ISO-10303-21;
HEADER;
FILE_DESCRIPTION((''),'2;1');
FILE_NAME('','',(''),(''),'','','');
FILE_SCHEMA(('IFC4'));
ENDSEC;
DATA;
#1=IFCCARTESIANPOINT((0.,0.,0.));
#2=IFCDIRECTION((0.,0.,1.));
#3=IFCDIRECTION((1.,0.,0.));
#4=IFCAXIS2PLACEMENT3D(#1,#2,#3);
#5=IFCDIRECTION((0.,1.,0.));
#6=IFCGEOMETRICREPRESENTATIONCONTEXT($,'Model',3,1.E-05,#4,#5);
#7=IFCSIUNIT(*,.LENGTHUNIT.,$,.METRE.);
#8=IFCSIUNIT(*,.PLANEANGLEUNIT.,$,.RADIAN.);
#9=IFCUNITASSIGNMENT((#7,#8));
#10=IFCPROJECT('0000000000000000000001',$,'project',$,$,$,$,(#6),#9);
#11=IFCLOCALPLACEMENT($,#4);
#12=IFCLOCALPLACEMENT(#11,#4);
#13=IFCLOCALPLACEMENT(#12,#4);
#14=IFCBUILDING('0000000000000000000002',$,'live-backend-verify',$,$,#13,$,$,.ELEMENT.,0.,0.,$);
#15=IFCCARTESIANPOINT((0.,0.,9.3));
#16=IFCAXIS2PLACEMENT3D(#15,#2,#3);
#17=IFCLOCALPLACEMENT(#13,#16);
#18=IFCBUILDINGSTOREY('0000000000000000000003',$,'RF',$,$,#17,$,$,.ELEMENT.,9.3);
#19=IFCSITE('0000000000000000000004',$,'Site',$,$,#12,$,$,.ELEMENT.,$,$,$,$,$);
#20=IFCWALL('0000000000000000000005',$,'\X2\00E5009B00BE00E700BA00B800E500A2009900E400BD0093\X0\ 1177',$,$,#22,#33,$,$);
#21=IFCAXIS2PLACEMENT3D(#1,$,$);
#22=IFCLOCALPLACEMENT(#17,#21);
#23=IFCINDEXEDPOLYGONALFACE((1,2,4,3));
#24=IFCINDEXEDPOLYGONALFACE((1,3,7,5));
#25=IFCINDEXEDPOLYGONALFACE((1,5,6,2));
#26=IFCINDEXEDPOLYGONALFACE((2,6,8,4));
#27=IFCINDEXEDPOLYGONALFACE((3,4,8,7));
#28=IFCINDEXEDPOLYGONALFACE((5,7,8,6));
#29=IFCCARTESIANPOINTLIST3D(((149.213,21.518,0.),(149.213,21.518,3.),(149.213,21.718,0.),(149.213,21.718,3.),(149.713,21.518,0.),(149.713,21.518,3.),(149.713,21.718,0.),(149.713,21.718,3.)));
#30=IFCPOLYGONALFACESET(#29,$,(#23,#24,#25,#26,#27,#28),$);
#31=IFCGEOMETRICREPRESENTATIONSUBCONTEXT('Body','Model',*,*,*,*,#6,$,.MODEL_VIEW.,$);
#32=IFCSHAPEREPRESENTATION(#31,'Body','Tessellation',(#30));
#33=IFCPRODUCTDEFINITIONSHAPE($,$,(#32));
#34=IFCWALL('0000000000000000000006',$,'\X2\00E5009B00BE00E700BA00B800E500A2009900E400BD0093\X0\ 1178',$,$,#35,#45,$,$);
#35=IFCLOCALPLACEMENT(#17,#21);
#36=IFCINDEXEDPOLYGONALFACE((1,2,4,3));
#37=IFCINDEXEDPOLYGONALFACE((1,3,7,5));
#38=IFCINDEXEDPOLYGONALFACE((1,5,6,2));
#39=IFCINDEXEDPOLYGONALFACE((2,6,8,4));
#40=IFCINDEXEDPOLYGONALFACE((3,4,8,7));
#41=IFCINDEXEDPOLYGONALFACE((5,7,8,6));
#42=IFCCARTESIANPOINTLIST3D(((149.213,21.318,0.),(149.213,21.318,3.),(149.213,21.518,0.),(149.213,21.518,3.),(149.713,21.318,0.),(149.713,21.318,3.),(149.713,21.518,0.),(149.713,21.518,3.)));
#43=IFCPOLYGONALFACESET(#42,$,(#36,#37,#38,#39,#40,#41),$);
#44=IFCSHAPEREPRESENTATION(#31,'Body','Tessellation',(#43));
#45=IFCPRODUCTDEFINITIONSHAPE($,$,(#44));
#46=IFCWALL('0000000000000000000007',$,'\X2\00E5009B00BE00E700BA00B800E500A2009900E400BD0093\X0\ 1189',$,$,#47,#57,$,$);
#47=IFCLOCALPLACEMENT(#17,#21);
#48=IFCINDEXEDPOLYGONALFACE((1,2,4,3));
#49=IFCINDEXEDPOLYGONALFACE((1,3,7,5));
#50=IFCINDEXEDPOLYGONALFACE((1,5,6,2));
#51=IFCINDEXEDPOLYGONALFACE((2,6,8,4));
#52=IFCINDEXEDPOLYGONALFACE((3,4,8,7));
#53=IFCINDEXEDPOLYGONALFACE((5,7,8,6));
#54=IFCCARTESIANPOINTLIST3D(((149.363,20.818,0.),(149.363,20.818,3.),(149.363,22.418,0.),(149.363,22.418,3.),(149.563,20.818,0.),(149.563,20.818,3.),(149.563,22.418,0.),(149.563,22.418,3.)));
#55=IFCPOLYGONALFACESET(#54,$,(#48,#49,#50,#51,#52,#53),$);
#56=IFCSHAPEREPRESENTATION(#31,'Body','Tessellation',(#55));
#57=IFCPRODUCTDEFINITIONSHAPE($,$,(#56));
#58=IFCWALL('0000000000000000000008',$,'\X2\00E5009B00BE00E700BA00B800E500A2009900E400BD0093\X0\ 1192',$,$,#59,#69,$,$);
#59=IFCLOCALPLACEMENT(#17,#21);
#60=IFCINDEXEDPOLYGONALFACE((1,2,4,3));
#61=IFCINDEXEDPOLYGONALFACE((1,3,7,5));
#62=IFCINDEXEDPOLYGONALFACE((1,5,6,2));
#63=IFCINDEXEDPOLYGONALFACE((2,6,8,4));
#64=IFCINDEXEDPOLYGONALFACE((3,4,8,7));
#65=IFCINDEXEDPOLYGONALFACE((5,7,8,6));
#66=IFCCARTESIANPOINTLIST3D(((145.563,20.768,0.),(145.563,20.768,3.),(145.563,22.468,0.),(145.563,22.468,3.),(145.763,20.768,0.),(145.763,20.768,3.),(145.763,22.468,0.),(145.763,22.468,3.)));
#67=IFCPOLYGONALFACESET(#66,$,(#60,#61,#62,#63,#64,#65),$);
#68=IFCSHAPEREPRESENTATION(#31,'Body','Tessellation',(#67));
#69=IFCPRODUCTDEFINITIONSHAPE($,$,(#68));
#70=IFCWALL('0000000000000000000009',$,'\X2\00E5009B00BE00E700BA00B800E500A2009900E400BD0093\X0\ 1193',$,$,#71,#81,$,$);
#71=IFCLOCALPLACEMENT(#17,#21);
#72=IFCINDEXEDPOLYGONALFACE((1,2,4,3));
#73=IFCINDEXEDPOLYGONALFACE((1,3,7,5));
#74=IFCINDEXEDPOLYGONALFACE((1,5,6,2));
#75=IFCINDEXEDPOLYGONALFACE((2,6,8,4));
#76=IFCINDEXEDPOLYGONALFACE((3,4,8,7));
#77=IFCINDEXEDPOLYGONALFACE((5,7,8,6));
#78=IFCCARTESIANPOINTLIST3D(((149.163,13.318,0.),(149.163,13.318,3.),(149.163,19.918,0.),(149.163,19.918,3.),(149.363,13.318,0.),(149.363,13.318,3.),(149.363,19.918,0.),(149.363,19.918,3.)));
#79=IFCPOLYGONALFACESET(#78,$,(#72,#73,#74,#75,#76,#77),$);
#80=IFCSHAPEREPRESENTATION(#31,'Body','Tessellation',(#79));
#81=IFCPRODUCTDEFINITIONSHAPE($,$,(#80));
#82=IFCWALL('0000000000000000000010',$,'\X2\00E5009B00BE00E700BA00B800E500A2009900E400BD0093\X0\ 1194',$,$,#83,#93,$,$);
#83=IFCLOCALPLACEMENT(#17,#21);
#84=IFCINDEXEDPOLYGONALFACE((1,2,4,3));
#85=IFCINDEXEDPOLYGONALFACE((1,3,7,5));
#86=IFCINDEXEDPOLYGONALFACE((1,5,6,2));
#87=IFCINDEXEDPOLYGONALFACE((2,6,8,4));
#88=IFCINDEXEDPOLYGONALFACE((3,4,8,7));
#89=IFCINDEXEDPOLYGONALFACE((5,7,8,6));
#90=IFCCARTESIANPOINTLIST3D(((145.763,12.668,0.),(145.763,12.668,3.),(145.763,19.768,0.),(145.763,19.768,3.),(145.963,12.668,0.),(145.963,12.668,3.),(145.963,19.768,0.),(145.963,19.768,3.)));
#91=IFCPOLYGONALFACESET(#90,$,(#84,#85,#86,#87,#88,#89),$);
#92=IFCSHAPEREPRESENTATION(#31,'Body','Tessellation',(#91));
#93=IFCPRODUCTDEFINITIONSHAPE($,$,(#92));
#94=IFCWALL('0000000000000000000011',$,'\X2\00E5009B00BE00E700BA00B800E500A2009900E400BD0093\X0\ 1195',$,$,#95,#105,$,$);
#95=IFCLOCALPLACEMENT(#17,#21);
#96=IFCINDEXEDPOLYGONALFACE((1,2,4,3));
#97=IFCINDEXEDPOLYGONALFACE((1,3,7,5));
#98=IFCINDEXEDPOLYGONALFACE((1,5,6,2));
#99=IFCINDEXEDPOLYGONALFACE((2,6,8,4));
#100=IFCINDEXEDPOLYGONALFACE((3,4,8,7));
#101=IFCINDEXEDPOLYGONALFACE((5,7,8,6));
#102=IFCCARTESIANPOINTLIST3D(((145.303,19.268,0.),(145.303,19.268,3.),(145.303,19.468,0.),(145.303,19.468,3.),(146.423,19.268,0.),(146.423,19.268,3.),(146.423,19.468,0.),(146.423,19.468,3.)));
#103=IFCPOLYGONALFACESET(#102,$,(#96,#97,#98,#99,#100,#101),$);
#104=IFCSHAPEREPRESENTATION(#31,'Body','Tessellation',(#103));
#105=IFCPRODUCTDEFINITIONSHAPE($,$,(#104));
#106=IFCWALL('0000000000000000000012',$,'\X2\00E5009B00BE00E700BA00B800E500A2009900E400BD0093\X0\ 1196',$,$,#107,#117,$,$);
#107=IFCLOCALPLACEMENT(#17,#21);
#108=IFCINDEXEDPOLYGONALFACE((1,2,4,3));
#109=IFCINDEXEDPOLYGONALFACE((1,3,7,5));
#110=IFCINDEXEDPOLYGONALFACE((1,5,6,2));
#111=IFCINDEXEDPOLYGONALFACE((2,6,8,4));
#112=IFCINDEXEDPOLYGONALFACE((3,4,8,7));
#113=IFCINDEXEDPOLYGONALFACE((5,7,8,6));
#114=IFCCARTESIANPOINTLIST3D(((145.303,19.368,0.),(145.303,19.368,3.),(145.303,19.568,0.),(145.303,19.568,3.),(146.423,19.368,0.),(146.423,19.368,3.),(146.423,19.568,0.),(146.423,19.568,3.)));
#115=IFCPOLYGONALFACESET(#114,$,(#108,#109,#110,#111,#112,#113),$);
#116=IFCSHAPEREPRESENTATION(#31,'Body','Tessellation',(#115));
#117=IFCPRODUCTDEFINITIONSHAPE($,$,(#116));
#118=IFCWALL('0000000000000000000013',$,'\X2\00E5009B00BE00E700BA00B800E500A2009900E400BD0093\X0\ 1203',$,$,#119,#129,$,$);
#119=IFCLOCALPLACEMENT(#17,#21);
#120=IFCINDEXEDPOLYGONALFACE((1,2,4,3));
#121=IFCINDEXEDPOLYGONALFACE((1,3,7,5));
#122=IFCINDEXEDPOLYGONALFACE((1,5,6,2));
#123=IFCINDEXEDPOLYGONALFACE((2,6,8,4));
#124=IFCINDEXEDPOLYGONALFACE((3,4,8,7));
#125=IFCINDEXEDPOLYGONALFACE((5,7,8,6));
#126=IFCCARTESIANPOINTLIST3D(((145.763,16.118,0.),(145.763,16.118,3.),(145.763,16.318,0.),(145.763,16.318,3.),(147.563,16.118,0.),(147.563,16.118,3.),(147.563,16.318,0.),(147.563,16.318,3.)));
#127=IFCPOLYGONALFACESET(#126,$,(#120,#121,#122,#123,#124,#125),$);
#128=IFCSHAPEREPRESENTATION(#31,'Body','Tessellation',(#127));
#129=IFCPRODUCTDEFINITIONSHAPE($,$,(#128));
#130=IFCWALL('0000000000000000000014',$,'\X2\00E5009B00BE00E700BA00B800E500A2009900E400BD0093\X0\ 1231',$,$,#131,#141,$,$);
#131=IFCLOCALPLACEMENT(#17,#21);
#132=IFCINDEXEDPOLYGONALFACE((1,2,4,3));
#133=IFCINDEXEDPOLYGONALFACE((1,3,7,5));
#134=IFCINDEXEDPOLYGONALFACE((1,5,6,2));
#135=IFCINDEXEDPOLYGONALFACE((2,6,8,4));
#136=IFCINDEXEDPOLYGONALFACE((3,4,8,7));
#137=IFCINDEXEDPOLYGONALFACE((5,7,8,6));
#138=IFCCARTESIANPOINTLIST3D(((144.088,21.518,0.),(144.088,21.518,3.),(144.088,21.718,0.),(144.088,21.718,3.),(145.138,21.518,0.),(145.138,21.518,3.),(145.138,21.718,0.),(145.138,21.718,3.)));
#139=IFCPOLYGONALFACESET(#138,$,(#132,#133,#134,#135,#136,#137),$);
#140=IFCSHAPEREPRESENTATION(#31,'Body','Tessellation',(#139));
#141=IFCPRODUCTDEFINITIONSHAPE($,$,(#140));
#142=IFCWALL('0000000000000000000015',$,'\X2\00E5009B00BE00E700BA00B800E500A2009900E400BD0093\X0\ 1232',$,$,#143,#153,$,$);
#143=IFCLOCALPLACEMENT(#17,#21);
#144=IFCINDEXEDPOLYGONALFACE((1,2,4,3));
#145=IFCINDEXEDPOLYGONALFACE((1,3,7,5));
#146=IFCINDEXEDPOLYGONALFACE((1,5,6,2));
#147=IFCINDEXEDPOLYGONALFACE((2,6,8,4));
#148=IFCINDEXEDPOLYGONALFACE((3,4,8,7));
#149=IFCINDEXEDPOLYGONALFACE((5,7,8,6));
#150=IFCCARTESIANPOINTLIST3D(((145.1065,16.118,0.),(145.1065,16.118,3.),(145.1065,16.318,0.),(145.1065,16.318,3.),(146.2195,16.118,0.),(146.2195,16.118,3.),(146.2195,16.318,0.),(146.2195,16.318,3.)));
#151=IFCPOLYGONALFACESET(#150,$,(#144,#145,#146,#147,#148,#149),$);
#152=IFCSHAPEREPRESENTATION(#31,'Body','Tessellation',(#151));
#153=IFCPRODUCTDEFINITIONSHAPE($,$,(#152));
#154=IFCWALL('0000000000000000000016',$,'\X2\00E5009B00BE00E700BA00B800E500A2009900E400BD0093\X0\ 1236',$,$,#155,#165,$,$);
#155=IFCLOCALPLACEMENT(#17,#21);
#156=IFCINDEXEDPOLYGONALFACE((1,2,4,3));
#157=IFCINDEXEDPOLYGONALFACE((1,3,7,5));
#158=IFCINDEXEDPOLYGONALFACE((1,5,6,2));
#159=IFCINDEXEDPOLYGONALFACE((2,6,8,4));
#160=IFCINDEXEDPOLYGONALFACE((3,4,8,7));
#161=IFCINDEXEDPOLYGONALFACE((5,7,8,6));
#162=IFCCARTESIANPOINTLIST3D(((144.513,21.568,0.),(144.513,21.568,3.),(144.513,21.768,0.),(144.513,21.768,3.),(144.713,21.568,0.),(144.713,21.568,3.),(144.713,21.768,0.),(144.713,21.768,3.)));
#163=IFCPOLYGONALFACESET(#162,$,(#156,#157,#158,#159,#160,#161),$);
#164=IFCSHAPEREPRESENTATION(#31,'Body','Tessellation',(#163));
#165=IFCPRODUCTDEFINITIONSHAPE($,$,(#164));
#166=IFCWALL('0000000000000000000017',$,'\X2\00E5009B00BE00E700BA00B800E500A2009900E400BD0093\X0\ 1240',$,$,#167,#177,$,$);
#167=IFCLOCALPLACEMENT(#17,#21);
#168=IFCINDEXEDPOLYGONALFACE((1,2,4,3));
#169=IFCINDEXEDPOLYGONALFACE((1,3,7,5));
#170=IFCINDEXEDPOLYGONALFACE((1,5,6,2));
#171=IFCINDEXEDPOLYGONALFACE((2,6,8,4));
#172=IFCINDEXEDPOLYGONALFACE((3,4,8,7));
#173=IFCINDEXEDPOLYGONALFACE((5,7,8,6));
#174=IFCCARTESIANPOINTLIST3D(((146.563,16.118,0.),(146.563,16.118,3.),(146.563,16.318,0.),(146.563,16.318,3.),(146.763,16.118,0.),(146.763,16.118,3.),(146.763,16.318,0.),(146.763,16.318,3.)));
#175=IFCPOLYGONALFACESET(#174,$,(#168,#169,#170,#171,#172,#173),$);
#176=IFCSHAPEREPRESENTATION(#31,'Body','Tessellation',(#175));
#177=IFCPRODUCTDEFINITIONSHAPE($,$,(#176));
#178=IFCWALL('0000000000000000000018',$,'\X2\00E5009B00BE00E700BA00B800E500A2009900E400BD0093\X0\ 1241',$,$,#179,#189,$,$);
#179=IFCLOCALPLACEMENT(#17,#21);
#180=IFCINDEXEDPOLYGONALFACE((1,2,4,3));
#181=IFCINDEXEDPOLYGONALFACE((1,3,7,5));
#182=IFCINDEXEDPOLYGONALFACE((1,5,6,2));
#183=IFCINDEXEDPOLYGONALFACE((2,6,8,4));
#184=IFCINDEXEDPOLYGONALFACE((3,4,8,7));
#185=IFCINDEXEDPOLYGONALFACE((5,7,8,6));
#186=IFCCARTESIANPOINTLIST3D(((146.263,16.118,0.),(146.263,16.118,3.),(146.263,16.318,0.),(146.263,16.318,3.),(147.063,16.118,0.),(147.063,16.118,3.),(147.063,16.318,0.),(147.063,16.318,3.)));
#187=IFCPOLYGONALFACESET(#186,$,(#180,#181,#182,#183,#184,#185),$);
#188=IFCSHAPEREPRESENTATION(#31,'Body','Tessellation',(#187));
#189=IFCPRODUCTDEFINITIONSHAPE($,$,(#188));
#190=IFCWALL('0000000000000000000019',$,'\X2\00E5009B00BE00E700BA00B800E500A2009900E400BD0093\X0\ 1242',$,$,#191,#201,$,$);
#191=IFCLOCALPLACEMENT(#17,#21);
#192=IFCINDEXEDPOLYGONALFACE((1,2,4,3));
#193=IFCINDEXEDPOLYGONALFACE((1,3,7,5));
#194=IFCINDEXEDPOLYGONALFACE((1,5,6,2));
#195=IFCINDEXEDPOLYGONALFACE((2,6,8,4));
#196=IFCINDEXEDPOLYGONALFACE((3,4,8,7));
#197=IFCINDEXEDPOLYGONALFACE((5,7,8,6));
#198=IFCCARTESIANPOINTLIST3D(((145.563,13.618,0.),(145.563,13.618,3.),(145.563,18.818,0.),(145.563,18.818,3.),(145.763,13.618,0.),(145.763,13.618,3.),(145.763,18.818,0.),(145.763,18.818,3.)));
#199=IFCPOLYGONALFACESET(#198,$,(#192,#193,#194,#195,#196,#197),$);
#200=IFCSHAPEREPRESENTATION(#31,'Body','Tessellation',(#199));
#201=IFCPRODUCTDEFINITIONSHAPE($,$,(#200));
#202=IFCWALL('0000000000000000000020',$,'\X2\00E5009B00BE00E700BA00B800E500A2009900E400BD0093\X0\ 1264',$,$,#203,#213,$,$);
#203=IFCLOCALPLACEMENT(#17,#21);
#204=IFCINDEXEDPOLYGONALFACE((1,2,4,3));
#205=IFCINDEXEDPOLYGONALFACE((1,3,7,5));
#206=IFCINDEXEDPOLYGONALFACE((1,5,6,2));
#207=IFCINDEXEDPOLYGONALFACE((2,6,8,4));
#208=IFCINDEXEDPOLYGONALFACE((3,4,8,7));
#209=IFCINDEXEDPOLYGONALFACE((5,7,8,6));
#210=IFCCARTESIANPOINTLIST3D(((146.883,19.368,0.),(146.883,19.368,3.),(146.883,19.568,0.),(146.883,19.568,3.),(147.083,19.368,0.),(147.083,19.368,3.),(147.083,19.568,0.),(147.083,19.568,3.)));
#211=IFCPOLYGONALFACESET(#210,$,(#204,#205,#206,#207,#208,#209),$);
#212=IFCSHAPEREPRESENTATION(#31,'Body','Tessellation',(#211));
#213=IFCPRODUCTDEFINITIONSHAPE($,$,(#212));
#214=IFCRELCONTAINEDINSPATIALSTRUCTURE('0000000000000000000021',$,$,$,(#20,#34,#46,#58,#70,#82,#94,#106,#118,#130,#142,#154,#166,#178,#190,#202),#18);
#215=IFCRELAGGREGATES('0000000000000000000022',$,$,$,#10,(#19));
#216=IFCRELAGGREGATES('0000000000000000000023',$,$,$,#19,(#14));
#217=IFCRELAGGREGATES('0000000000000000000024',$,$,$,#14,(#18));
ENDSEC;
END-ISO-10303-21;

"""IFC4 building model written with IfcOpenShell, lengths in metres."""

from ifc_helpers import new_model, si_unit, direction, frame, frame_2d, origin_with_axes, place, context, subcontext, project, spatial, rectangle, extrude, element, save


model = new_model("IFC4")

# Units and contexts
model_context = context("Model", 3, precision=1e-05, world=origin_with_axes(), true_north=direction((0.0, 1.0, 0.0)))
body_context = subcontext(model_context, "Body", "Model", "MODEL_VIEW")
ifc_project = project(units=[si_unit("LENGTHUNIT", "METRE"), si_unit("PLANEANGLEUNIT", "RADIAN")], contexts=[model_context])

# Site, building, storey
placement = place(None, origin_with_axes())
site_placement = place(placement, origin_with_axes())
site = spatial("IfcSite", under=ifc_project, at=site_placement, Name="Site", CompositionType="ELEMENT")
building_placement = place(site_placement, origin_with_axes())
building = spatial("IfcBuilding", under=site, at=building_placement, Name="live-backend-verify", CompositionType="ELEMENT", ElevationOfRefHeight=0.0, ElevationOfTerrain=0.0)
storey_placement = place(building_placement, frame((0.0, 0.0, 9.3), z_axis=(0.0, 0.0, 1.0), x_axis=(1.0, 0.0, 0.0)))
storey = spatial("IfcBuildingStorey", under=building, at=storey_placement, Name="RF", CompositionType="ELEMENT", Elevation=9.3)

# Walls
for number, where, z_axis, x_axis, name in (
    (1, (149.463, 21.618, 0.0), (0.0, 0.0, 1.0), (1.0, 0.0, 0.0), "å\u009b¾çº¸å¢\u0099ä½\u0093 1177"),
    (2, (149.463, 21.418, 0.0), (0.0, 0.0, 1.0), (1.0, 0.0, 0.0), "å\u009b¾çº¸å¢\u0099ä½\u0093 1178"),
):
    element("IfcWall", number, at=place(storey_placement, frame(where, z_axis=z_axis, x_axis=x_axis)), inside=storey, Name=name, context=body_context, shape_type="SweptSolid", body=[
        extrude(rectangle(XDim=0.5, YDim=0.2, at=frame_2d((0.0, 0.0), x_axis=(1.0, 0.0, 0.0))), frame((0.0, 0.0, 0.0), z_axis=(0.0, 0.0, 1.0)), (0.0, 0.0, 1.0), 3.0),
    ])
wall_1_placement = place(storey_placement, frame((149.463, 21.618, 0.0), z_axis=(0.0, 0.0, 1.0), x_axis=(0.0, 1.0, 0.0)))
element("IfcWall", 3, at=wall_1_placement, inside=storey, Name="å\u009b¾çº¸å¢\u0099ä½\u0093 1189", context=body_context, shape_type="SweptSolid", body=[
    extrude(rectangle(XDim=1.6, YDim=0.2, at=frame_2d((0.0, 0.0), x_axis=(1.0, 0.0, 0.0))), frame((0.0, 0.0, 0.0), z_axis=(0.0, 0.0, 1.0)), (0.0, 0.0, 1.0), 3.0),
])
wall_2_placement = place(storey_placement, frame((145.663, 21.618, 0.0), z_axis=(0.0, 0.0, 1.0), x_axis=(0.0, 1.0, 0.0)))
element("IfcWall", 4, at=wall_2_placement, inside=storey, Name="å\u009b¾çº¸å¢\u0099ä½\u0093 1192", context=body_context, shape_type="SweptSolid", body=[
    extrude(rectangle(XDim=1.7, YDim=0.2, at=frame_2d((0.0, 0.0), x_axis=(1.0, 0.0, 0.0))), frame((0.0, 0.0, 0.0), z_axis=(0.0, 0.0, 1.0)), (0.0, 0.0, 1.0), 3.0),
])
wall_3_placement = place(storey_placement, frame((149.263, 16.618, 0.0), z_axis=(0.0, 0.0, 1.0), x_axis=(0.0, 1.0, 0.0)))
element("IfcWall", 5, at=wall_3_placement, inside=storey, Name="å\u009b¾çº¸å¢\u0099ä½\u0093 1193", context=body_context, shape_type="SweptSolid", body=[
    extrude(rectangle(XDim=6.6, YDim=0.2, at=frame_2d((0.0, 0.0), x_axis=(1.0, 0.0, 0.0))), frame((0.0, 0.0, 0.0), z_axis=(0.0, 0.0, 1.0)), (0.0, 0.0, 1.0), 3.0),
])
wall_4_placement = place(storey_placement, frame((145.863, 16.218, 0.0), z_axis=(0.0, 0.0, 1.0), x_axis=(0.0, 1.0, 0.0)))
element("IfcWall", 6, at=wall_4_placement, inside=storey, Name="å\u009b¾çº¸å¢\u0099ä½\u0093 1194", context=body_context, shape_type="SweptSolid", body=[
    extrude(rectangle(XDim=7.1, YDim=0.2, at=frame_2d((0.0, 0.0), x_axis=(1.0, 0.0, 0.0))), frame((0.0, 0.0, 0.0), z_axis=(0.0, 0.0, 1.0)), (0.0, 0.0, 1.0), 3.0),
])
for number, where, z_axis, x_axis, name in (
    (7, (145.863, 19.368, 0.0), (0.0, 0.0, 1.0), (1.0, 0.0, 0.0), "å\u009b¾çº¸å¢\u0099ä½\u0093 1195"),
    (8, (145.863, 19.468, 0.0), (0.0, 0.0, 1.0), (1.0, 0.0, 0.0), "å\u009b¾çº¸å¢\u0099ä½\u0093 1196"),
):
    element("IfcWall", number, at=place(storey_placement, frame(where, z_axis=z_axis, x_axis=x_axis)), inside=storey, Name=name, context=body_context, shape_type="SweptSolid", body=[
        extrude(rectangle(XDim=1.12, YDim=0.2, at=frame_2d((0.0, 0.0), x_axis=(1.0, 0.0, 0.0))), frame((0.0, 0.0, 0.0), z_axis=(0.0, 0.0, 1.0)), (0.0, 0.0, 1.0), 3.0),
    ])
wall_5_placement = place(storey_placement, frame((146.663, 16.218, 0.0), z_axis=(0.0, 0.0, 1.0), x_axis=(1.0, 0.0, 0.0)))
element("IfcWall", 9, at=wall_5_placement, inside=storey, Name="å\u009b¾çº¸å¢\u0099ä½\u0093 1203", context=body_context, shape_type="SweptSolid", body=[
    extrude(rectangle(XDim=1.8, YDim=0.2, at=frame_2d((0.0, 0.0), x_axis=(1.0, 0.0, 0.0))), frame((0.0, 0.0, 0.0), z_axis=(0.0, 0.0, 1.0)), (0.0, 0.0, 1.0), 3.0),
])
wall_6_placement = place(storey_placement, frame((144.613, 21.618, 0.0), z_axis=(0.0, 0.0, 1.0), x_axis=(1.0, 0.0, 0.0)))
element("IfcWall", 10, at=wall_6_placement, inside=storey, Name="å\u009b¾çº¸å¢\u0099ä½\u0093 1231", context=body_context, shape_type="SweptSolid", body=[
    extrude(rectangle(XDim=1.05, YDim=0.2, at=frame_2d((0.0, 0.0), x_axis=(1.0, 0.0, 0.0))), frame((0.0, 0.0, 0.0), z_axis=(0.0, 0.0, 1.0)), (0.0, 0.0, 1.0), 3.0),
])
wall_7_placement = place(storey_placement, frame((145.663, 16.218, 0.0), z_axis=(0.0, 0.0, 1.0), x_axis=(-1.0, 0.0, 0.0)))
element("IfcWall", 11, at=wall_7_placement, inside=storey, Name="å\u009b¾çº¸å¢\u0099ä½\u0093 1232", context=body_context, shape_type="SweptSolid", body=[
    extrude(rectangle(XDim=1.113, YDim=0.2, at=frame_2d((0.0, 0.0), x_axis=(1.0, 0.0, 0.0))), frame((0.0, 0.0, 0.0), z_axis=(0.0, 0.0, 1.0)), (0.0, 0.0, 1.0), 3.0),
])
for number, where, z_axis, x_axis, name in (
    (12, (144.613, 21.668, 0.0), (0.0, 0.0, 1.0), (-1.0, 0.0, 0.0), "å\u009b¾çº¸å¢\u0099ä½\u0093 1236"),
    (13, (146.663, 16.218, 0.0), (0.0, 0.0, 1.0), (0.0, -1.0, 0.0), "å\u009b¾çº¸å¢\u0099ä½\u0093 1240"),
):
    element("IfcWall", number, at=place(storey_placement, frame(where, z_axis=z_axis, x_axis=x_axis)), inside=storey, Name=name, context=body_context, shape_type="SweptSolid", body=[
        extrude(rectangle(XDim=0.2, YDim=0.2, at=frame_2d((0.0, 0.0), x_axis=(1.0, 0.0, 0.0))), frame((0.0, 0.0, 0.0), z_axis=(0.0, 0.0, 1.0)), (0.0, 0.0, 1.0), 3.0),
    ])
wall_8_placement = place(storey_placement, frame((146.663, 16.218, 0.0), z_axis=(0.0, 0.0, 1.0), x_axis=(-1.0, 0.0, 0.0)))
element("IfcWall", 14, at=wall_8_placement, inside=storey, Name="å\u009b¾çº¸å¢\u0099ä½\u0093 1241", context=body_context, shape_type="SweptSolid", body=[
    extrude(rectangle(XDim=0.8, YDim=0.2, at=frame_2d((0.0, 0.0), x_axis=(1.0, 0.0, 0.0))), frame((0.0, 0.0, 0.0), z_axis=(0.0, 0.0, 1.0)), (0.0, 0.0, 1.0), 3.0),
])
wall_9_placement = place(storey_placement, frame((145.663, 16.218, 0.0), z_axis=(0.0, 0.0, 1.0), x_axis=(0.0, 1.0, 0.0)))
element("IfcWall", 15, at=wall_9_placement, inside=storey, Name="å\u009b¾çº¸å¢\u0099ä½\u0093 1242", context=body_context, shape_type="SweptSolid", body=[
    extrude(rectangle(XDim=5.2, YDim=0.2, at=frame_2d((0.0, 0.0), x_axis=(1.0, 0.0, 0.0))), frame((0.0, 0.0, 0.0), z_axis=(0.0, 0.0, 1.0)), (0.0, 0.0, 1.0), 3.0),
])
for number, where, z_axis, x_axis, name in (
    (16, (146.983, 19.468, 0.0), (0.0, 0.0, 1.0), (0.0, -1.0, 0.0), "å\u009b¾çº¸å¢\u0099ä½\u0093 1264"),
):
    element("IfcWall", number, at=place(storey_placement, frame(where, z_axis=z_axis, x_axis=x_axis)), inside=storey, Name=name, context=body_context, shape_type="SweptSolid", body=[
        extrude(rectangle(XDim=0.2, YDim=0.2, at=frame_2d((0.0, 0.0), x_axis=(1.0, 0.0, 0.0))), frame((0.0, 0.0, 0.0), z_axis=(0.0, 0.0, 1.0)), (0.0, 0.0, 1.0), 3.0),
    ])

save(model, "model.ifc")
